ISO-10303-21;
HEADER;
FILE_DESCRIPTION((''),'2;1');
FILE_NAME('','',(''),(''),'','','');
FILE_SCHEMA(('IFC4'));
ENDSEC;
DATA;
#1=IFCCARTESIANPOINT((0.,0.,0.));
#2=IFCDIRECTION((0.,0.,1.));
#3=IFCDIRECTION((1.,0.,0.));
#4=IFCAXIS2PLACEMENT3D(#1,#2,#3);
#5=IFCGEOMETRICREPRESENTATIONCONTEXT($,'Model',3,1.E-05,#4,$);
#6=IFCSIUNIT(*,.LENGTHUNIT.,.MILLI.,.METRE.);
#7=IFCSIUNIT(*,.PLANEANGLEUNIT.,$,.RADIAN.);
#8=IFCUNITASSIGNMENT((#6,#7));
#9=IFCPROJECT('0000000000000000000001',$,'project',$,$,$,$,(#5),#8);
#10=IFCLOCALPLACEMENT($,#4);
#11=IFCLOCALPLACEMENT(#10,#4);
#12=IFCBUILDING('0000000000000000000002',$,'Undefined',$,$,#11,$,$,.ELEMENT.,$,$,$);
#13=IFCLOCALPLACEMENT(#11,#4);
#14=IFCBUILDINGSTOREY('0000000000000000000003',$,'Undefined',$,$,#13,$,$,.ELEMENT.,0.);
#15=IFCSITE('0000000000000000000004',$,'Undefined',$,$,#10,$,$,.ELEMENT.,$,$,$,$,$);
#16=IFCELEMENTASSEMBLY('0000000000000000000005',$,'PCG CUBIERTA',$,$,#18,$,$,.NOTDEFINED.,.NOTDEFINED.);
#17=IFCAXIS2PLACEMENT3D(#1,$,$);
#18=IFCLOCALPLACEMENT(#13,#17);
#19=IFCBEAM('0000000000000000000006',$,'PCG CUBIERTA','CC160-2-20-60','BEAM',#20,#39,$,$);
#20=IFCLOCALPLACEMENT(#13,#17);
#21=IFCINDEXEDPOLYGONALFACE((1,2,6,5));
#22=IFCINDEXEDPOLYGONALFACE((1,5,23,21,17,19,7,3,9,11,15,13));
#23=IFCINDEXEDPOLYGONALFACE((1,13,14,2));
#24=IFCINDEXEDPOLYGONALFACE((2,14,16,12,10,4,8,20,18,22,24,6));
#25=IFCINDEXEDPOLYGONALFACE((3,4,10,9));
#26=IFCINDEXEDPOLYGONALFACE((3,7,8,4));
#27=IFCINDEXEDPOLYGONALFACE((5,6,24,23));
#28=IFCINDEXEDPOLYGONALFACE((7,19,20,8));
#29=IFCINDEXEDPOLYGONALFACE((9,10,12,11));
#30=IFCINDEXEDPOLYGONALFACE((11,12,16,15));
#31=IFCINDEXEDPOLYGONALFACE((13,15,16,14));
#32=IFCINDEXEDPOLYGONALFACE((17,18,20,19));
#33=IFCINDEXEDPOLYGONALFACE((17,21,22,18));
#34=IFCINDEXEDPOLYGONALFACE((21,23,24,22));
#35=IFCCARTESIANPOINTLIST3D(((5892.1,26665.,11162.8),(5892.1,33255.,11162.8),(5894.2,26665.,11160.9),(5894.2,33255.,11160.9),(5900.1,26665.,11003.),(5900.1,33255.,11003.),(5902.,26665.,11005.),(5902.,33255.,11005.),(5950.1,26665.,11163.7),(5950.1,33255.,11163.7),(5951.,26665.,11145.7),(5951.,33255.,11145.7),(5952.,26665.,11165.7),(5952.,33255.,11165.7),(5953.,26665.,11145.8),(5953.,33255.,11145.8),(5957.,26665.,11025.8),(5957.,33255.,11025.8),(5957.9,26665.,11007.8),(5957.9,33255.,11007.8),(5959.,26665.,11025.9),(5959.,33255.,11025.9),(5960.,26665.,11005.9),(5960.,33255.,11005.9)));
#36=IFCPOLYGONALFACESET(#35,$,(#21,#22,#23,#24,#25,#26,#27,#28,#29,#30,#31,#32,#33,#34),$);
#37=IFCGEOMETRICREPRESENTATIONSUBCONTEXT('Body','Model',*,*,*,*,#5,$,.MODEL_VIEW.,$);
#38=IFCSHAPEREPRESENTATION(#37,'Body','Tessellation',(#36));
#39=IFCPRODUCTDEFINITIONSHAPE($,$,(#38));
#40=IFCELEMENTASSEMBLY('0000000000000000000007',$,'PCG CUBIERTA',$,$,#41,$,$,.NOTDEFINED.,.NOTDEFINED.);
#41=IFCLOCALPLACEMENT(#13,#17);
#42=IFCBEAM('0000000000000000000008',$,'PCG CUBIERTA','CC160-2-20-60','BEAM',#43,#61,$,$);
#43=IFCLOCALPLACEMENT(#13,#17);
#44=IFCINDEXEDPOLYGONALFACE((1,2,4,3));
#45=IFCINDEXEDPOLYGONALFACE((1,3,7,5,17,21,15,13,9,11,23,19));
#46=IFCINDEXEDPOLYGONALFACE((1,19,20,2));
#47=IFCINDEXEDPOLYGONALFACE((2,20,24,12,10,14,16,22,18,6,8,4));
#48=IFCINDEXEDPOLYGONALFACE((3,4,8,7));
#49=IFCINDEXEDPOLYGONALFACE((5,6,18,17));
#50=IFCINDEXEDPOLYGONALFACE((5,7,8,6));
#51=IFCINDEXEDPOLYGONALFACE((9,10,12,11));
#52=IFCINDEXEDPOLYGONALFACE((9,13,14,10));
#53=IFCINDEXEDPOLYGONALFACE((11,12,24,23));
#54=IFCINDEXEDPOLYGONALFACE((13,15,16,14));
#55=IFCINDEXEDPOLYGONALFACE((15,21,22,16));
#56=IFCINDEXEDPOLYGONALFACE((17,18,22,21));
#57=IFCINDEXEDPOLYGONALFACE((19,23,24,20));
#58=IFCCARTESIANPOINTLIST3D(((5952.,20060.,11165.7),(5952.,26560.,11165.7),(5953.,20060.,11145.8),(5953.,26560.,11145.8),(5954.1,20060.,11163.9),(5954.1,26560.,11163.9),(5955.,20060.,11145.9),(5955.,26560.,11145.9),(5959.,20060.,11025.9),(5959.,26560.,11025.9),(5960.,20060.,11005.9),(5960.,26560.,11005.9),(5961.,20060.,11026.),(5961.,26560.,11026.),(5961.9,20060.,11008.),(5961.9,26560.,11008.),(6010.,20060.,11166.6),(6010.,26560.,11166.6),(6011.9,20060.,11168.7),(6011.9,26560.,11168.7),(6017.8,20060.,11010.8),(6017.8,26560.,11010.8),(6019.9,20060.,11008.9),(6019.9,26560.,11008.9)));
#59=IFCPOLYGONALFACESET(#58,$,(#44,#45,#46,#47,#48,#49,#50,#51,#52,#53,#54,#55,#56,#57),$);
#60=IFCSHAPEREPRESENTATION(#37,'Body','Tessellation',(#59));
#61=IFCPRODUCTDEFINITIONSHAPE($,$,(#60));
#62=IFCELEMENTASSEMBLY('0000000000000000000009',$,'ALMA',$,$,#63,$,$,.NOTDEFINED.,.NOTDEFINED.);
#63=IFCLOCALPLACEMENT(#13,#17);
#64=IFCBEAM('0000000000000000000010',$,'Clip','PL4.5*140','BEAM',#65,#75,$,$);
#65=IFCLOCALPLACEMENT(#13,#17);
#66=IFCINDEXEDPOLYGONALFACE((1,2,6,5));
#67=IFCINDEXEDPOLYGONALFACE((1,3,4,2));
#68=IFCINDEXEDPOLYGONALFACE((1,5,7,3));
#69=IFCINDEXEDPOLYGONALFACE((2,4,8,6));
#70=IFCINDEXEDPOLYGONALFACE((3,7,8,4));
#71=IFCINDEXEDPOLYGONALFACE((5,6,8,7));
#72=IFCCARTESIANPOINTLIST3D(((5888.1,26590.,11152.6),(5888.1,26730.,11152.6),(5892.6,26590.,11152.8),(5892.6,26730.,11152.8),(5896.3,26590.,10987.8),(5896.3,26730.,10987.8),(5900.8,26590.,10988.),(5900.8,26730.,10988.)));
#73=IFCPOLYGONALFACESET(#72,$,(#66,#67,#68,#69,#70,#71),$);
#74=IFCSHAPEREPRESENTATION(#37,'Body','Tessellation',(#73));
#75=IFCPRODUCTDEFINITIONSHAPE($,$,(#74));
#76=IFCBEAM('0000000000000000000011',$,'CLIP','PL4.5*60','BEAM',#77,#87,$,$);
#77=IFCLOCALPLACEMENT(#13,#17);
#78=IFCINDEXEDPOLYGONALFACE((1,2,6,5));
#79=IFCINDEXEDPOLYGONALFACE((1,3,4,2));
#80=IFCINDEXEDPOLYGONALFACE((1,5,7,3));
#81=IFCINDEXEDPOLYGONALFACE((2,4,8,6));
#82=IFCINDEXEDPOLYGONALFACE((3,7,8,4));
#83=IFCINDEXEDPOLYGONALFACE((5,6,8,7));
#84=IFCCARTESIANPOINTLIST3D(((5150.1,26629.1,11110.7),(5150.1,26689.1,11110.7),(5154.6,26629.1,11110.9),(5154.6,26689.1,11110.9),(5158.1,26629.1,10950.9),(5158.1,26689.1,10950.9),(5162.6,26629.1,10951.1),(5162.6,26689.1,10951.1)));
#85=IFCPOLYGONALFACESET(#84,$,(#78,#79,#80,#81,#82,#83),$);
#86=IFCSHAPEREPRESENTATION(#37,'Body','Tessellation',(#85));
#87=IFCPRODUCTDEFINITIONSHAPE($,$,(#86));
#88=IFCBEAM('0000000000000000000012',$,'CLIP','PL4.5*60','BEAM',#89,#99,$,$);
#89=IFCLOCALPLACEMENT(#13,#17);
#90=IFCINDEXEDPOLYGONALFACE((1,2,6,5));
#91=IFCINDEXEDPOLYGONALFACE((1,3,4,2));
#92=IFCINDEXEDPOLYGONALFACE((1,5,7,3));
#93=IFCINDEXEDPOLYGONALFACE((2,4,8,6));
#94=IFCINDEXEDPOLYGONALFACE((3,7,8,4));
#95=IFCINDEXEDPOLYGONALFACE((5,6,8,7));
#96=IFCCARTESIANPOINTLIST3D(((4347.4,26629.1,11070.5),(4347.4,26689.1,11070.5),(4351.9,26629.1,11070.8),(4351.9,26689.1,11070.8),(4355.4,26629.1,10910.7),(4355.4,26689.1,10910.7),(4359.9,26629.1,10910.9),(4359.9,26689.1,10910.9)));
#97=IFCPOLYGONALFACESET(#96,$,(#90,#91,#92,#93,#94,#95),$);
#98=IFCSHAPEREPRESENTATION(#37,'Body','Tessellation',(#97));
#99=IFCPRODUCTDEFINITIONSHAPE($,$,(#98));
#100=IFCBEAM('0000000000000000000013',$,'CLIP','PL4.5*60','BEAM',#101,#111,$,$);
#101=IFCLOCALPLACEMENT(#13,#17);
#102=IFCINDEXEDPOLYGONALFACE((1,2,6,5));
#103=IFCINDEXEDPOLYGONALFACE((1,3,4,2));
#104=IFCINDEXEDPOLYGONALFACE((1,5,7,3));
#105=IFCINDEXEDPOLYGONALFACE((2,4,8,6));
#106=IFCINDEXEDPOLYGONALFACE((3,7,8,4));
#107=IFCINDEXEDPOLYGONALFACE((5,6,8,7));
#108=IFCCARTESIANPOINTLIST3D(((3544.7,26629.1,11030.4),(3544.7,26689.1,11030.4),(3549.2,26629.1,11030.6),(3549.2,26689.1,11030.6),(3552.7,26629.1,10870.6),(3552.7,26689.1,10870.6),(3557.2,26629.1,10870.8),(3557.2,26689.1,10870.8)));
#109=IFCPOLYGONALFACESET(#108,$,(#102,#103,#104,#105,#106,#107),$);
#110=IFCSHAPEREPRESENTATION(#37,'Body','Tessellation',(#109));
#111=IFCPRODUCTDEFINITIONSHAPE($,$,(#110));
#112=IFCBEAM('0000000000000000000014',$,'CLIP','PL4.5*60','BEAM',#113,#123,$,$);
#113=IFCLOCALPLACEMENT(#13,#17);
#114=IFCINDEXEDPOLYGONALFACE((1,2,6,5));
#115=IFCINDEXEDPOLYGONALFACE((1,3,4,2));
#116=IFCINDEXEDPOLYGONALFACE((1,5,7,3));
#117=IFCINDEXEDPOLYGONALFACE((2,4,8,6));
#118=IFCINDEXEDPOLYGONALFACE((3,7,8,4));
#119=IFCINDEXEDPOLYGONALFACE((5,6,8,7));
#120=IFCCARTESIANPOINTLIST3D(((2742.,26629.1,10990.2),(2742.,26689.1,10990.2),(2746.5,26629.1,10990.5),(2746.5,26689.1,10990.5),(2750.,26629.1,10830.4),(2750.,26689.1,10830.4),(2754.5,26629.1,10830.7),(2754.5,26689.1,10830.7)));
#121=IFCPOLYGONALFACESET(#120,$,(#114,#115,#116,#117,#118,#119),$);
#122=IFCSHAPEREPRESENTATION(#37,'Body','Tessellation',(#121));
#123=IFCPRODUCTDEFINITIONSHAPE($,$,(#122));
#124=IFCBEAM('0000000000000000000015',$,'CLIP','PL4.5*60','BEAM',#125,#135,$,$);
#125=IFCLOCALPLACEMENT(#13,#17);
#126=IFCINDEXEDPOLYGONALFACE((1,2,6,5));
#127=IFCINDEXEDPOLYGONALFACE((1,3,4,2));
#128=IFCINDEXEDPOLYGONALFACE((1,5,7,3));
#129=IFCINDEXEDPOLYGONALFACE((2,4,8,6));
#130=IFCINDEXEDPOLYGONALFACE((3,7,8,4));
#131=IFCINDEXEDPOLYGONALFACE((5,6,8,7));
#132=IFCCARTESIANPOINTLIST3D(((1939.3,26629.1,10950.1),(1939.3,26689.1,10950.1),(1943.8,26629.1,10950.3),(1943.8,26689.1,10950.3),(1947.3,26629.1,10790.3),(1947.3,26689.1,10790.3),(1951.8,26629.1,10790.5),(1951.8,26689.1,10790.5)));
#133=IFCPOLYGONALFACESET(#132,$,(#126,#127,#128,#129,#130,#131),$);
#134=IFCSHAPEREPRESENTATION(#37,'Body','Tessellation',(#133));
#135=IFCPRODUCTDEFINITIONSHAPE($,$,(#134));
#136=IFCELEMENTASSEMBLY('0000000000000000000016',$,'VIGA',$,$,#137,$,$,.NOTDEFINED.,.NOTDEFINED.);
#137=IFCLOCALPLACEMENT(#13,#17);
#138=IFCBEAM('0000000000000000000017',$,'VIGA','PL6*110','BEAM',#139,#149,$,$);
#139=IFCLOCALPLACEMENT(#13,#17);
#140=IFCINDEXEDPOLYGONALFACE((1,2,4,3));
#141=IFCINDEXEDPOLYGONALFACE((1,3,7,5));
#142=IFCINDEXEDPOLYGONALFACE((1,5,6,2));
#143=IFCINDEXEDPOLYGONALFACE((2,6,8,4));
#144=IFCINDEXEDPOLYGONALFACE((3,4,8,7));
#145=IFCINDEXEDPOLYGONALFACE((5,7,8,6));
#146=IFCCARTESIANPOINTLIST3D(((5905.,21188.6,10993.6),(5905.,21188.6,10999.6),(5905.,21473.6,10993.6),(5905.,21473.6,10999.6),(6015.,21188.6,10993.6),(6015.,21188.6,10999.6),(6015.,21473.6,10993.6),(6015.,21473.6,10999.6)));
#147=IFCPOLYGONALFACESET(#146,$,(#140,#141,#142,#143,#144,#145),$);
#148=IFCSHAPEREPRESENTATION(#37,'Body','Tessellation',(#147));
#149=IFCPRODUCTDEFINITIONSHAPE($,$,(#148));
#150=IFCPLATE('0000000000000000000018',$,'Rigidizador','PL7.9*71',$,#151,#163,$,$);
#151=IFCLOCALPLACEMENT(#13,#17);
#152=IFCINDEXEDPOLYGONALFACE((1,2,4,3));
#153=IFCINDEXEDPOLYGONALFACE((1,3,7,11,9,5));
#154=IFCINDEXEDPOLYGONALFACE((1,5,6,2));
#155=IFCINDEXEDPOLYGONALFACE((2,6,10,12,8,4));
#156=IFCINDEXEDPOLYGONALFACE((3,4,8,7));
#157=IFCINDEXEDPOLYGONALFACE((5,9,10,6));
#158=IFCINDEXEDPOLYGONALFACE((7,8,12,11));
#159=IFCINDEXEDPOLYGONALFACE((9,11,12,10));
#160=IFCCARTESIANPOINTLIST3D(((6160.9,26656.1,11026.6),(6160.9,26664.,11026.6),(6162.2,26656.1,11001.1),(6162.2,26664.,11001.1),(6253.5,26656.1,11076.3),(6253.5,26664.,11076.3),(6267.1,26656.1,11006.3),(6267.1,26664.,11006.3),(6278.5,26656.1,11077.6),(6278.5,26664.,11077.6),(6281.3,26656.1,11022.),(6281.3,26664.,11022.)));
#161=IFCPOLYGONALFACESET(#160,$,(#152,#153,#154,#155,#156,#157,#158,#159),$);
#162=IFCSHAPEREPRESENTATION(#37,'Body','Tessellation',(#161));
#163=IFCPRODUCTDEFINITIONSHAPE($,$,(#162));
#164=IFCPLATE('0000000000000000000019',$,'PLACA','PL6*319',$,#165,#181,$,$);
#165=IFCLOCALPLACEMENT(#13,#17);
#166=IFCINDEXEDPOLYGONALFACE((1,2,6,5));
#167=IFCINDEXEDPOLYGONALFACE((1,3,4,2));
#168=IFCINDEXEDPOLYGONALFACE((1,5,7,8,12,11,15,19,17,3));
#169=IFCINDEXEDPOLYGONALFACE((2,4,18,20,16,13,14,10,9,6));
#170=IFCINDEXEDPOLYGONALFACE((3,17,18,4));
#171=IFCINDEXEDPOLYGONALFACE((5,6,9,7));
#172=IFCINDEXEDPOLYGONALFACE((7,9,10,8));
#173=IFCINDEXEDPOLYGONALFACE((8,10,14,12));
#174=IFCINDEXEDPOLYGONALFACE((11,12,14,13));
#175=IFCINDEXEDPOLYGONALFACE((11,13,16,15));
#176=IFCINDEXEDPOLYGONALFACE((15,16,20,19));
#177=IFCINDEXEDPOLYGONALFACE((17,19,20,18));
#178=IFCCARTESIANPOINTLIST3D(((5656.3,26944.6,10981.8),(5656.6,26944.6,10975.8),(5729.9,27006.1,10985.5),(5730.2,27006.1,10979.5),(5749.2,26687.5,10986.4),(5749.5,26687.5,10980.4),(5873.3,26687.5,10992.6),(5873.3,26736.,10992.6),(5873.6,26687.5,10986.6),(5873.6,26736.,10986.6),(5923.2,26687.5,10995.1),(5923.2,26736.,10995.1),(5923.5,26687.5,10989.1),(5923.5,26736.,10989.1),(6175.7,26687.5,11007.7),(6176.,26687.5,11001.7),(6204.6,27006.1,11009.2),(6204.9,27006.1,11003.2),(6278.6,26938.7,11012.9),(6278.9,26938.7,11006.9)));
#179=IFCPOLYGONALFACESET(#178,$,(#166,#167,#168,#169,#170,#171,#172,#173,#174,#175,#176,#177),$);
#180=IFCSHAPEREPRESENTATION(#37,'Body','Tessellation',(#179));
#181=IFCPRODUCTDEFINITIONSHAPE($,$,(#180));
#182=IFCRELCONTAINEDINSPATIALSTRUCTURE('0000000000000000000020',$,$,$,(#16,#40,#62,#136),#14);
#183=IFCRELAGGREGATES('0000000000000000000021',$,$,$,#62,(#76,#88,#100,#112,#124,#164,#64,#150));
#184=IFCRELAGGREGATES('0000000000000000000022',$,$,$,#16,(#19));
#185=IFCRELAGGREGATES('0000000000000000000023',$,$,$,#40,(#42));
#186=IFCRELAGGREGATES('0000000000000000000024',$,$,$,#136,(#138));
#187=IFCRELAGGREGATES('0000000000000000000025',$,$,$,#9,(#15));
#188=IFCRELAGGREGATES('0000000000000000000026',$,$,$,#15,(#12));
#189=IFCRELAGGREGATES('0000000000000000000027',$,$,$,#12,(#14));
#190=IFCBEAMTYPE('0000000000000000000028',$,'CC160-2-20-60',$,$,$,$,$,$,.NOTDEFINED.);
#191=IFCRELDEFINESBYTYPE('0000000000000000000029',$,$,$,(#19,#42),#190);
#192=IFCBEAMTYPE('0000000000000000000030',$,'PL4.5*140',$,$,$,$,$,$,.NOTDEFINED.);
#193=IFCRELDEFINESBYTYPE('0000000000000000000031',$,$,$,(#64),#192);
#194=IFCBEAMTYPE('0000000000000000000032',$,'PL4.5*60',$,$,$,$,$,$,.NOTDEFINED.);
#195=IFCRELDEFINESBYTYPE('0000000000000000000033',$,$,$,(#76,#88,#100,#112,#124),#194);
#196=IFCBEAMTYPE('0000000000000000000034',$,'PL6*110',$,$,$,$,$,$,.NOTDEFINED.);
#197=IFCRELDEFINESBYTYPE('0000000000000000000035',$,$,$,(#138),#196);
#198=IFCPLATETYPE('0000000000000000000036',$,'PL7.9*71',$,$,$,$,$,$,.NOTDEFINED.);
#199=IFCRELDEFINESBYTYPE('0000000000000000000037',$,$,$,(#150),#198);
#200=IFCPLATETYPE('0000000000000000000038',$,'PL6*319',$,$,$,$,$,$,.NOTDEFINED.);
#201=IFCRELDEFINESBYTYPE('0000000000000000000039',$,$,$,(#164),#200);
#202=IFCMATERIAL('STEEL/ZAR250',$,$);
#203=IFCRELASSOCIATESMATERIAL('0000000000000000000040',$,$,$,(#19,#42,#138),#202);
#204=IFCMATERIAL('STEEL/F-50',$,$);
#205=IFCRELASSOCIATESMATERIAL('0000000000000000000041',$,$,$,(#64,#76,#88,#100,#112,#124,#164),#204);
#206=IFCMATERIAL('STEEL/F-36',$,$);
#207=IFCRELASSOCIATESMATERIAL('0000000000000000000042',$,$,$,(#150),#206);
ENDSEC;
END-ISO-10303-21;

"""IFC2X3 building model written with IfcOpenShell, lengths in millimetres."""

from ifc_helpers import new_model, si_unit, frame, origin_with_axes, origin_2d_with_axis, place, context, subcontext, project, spatial, polyline, rectangle, c_section, outline, extrude, boolean, material, type_object, element, aggregate, save


model = new_model("IFC2X3")

# Units and contexts
model_context = context("Model", 3, precision=1e-05, world=origin_with_axes())
body_context = subcontext(model_context, "Body", "Model", "MODEL_VIEW")
ifc_project = project(units=[si_unit("LENGTHUNIT", "METRE", prefix="MILLI"), si_unit("PLANEANGLEUNIT", "RADIAN")], contexts=[model_context])

# Site, building, storey
site_placement = place(None, origin_with_axes())
site = spatial("IfcSite", under=ifc_project, at=site_placement, Name="Undefined", CompositionType="ELEMENT")
building_placement = place(site_placement, origin_with_axes())
building = spatial("IfcBuilding", under=site, at=building_placement, Name="Undefined", CompositionType="ELEMENT")
storey_placement = place(building_placement, origin_with_axes())
storey = spatial("IfcBuildingStorey", under=building, at=storey_placement, Name="Undefined", CompositionType="ELEMENT", Elevation=0.0)

# Element assemblies, beams
assembly_1_placement = place(storey_placement, origin_with_axes())
assembly_1 = element("IfcElementAssembly", 1, at=assembly_1_placement, inside=storey, Name="PCG CUBIERTA", AssemblyPlace="NOTDEFINED", PredefinedType="NOTDEFINED")
ifc_material_1 = material(Name="STEEL/ZAR250")
beam_type_1 = type_object("IfcBeamType", Name="CC160-2-20-60", PredefinedType="NOTDEFINED")
beam_1_placement = place(assembly_1_placement, frame((5926.0, 26665.0, 11084.4), z_axis=(-0.049943, 0.0, 0.998752), x_axis=(0.0, 1.0, 0.0)))
beam_1 = element("IfcBeam", 2, at=beam_1_placement, type_object=beam_type_1, material=ifc_material_1, Name="PCG CUBIERTA", Description="CC160-2-20-60", ObjectType="BEAM", context=body_context, shape_type="SweptSolid", body=[
    extrude(c_section(Depth=160.0, Width=60.0, WallThickness=2.0, Girth=20.0, at=origin_2d_with_axis()), frame((6590.0, 0.0, 0.0), z_axis=(-1.0, 0.0, 0.0), x_axis=(0.0, -1.0, 0.0)), (0.0, 0.0, 1.0), 6590.0),
])
assembly_2_placement = place(storey_placement, origin_with_axes())
assembly_2 = element("IfcElementAssembly", 3, at=assembly_2_placement, inside=storey, Name="PCG CUBIERTA", AssemblyPlace="NOTDEFINED", PredefinedType="NOTDEFINED")
beam_2_placement = place(assembly_2_placement, frame((5986.0, 26560.0, 11087.3), z_axis=(-0.049943, 0.0, 0.998752), x_axis=(0.0, -1.0, 0.0)))
beam_2 = element("IfcBeam", 4, at=beam_2_placement, type_object=beam_type_1, material=ifc_material_1, Name="PCG CUBIERTA", Description="CC160-2-20-60", ObjectType="BEAM", context=body_context, shape_type="SweptSolid", body=[
    extrude(c_section(Depth=160.0, Width=60.0, WallThickness=2.0, Girth=20.0, at=origin_2d_with_axis()), frame((6500.0, 0.0, 0.0), z_axis=(-1.0, 0.0, 0.0), x_axis=(0.0, -1.0, 0.0)), (0.0, 0.0, 1.0), 6500.0),
])

# Element assembly, beams
assembly_3_placement = place(storey_placement, origin_with_axes())
assembly_3 = element("IfcElementAssembly", 5, at=assembly_3_placement, inside=storey, Name="ALMA", AssemblyPlace="NOTDEFINED", PredefinedType="NOTDEFINED")
ifc_material_2 = material(Name="STEEL/F-50")
beam_type_2 = type_object("IfcBeamType", Name="PL4.5*140", PredefinedType="NOTDEFINED")
beam_3_placement = place(assembly_3_placement, frame((5890.3, 26660.0, 11152.7), z_axis=(0.0, -1.0, 0.0), x_axis=(0.049943, 0.0, -0.998752)))
beam_3 = element("IfcBeam", 6, at=beam_3_placement, type_object=beam_type_2, material=ifc_material_2, Name="Clip", Description="PL4.5*140", ObjectType="BEAM", context=body_context, shape_type="SweptSolid", body=[
    extrude(rectangle(XDim=4.5, YDim=140.0, at=origin_2d_with_axis()), frame((165.0, 0.0, 0.0), z_axis=(-1.0, 0.0, 0.0), x_axis=(0.0, -1.0, 0.0)), (0.0, 0.0, 1.0), 165.0),
])
beam_type_3 = type_object("IfcBeamType", Name="PL4.5*60", PredefinedType="NOTDEFINED")
beam_4_placement = place(assembly_3_placement, frame((5152.3, 26659.1, 11110.8), z_axis=(0.0, 1.0, 0.0), x_axis=(0.049943, 0.0, -0.998752)))
beam_4 = element("IfcBeam", 7, at=beam_4_placement, type_object=beam_type_3, material=ifc_material_2, Name="CLIP", Description="PL4.5*60", ObjectType="BEAM", context=body_context, shape_type="SweptSolid", body=[
    extrude(rectangle(XDim=4.5, YDim=60.0, at=origin_2d_with_axis()), frame((160.0, 0.0, 0.0), z_axis=(-1.0, 0.0, 0.0), x_axis=(0.0, -1.0, 0.0)), (0.0, 0.0, 1.0), 160.0),
])
beam_5_placement = place(assembly_3_placement, frame((4349.6, 26659.1, 11070.6), z_axis=(0.0, 1.0, 0.0), x_axis=(0.049943, 0.0, -0.998752)))
beam_5 = element("IfcBeam", 8, at=beam_5_placement, type_object=beam_type_3, material=ifc_material_2, Name="CLIP", Description="PL4.5*60", ObjectType="BEAM", context=body_context, shape_type="SweptSolid", body=[
    extrude(rectangle(XDim=4.5, YDim=60.0, at=origin_2d_with_axis()), frame((160.0, 0.0, 0.0), z_axis=(-1.0, 0.0, 0.0), x_axis=(0.0, -1.0, 0.0)), (0.0, 0.0, 1.0), 160.0),
])
beam_6_placement = place(assembly_3_placement, frame((3546.9, 26659.1, 11030.5), z_axis=(0.0, 1.0, 0.0), x_axis=(0.049943, 0.0, -0.998752)))
beam_6 = element("IfcBeam", 9, at=beam_6_placement, type_object=beam_type_3, material=ifc_material_2, Name="CLIP", Description="PL4.5*60", ObjectType="BEAM", context=body_context, shape_type="SweptSolid", body=[
    extrude(rectangle(XDim=4.5, YDim=60.0, at=origin_2d_with_axis()), frame((160.0, 0.0, 0.0), z_axis=(-1.0, 0.0, 0.0), x_axis=(0.0, -1.0, 0.0)), (0.0, 0.0, 1.0), 160.0),
])
beam_7_placement = place(assembly_3_placement, frame((2744.2, 26659.1, 10990.4), z_axis=(0.0, 1.0, 0.0), x_axis=(0.049943, 0.0, -0.998752)))
beam_7 = element("IfcBeam", 10, at=beam_7_placement, type_object=beam_type_3, material=ifc_material_2, Name="CLIP", Description="PL4.5*60", ObjectType="BEAM", context=body_context, shape_type="SweptSolid", body=[
    extrude(rectangle(XDim=4.5, YDim=60.0, at=origin_2d_with_axis()), frame((160.0, 0.0, 0.0), z_axis=(-1.0, 0.0, 0.0), x_axis=(0.0, -1.0, 0.0)), (0.0, 0.0, 1.0), 160.0),
])
beam_8_placement = place(assembly_3_placement, frame((1941.6, 26659.1, 10950.2), z_axis=(0.0, 1.0, 0.0), x_axis=(0.049943, 0.0, -0.998752)))
beam_8 = element("IfcBeam", 11, at=beam_8_placement, type_object=beam_type_3, material=ifc_material_2, Name="CLIP", Description="PL4.5*60", ObjectType="BEAM", context=body_context, shape_type="SweptSolid", body=[
    extrude(rectangle(XDim=4.5, YDim=60.0, at=origin_2d_with_axis()), frame((160.0, 0.0, 0.0), z_axis=(-1.0, 0.0, 0.0), x_axis=(0.0, -1.0, 0.0)), (0.0, 0.0, 1.0), 160.0),
])

# Element assembly, beam
assembly_4_placement = place(storey_placement, origin_with_axes())
assembly_4 = element("IfcElementAssembly", 12, at=assembly_4_placement, inside=storey, Name="VIGA", AssemblyPlace="NOTDEFINED", PredefinedType="NOTDEFINED")
beam_type_4 = type_object("IfcBeamType", Name="PL6*110", PredefinedType="NOTDEFINED")
beam_9_placement = place(assembly_4_placement, frame((5960.0, 21473.6, 10996.6), z_axis=(-1.0, 0.0, 0.0), x_axis=(0.0, -1.0, 0.0)))
beam_9 = element("IfcBeam", 13, at=beam_9_placement, type_object=beam_type_4, material=ifc_material_1, Name="VIGA", Description="PL6*110", ObjectType="BEAM", context=body_context, shape_type="SweptSolid", body=[
    extrude(rectangle(XDim=6.0, YDim=110.0, at=origin_2d_with_axis()), frame((285.0, 0.0, 0.0), z_axis=(-1.0, 0.0, 0.0), x_axis=(0.0, -1.0, 0.0)), (0.0, 0.0, 1.0), 285.0),
])

# Plates
ifc_material_3 = material(Name="STEEL/F-36")
plate_type_1 = type_object("IfcPlateType", Name="PL7.9*71", PredefinedType="NOTDEFINED")
plate_1_placement = place(assembly_3_placement, frame((6278.5, 26660.0, 11077.6), z_axis=(0.0, 1.0, 0.0), x_axis=(0.049943, 0.0, -0.998752)))
plate_1 = element("IfcPlate", 14, at=plate_1_placement, type_object=plate_type_1, material=ifc_material_3, Name="Rigidizador", Description="PL7.9*71", context=body_context, shape_type="SweptSolid", body=[
    extrude(outline(polyline([(0.0, 0.0), (55.6, 0.0), (70.6, 15.0), (70.6, 120.0), (45.0, 120.0), (0.0, 25.0), (0.0, 0.0)])), frame((0.0, 0.0, -4.0), z_axis=(0.0, 0.0, 1.0), x_axis=(1.0, 0.0, 0.0)), (0.0, 0.0, 1.0), 7.9),
])
plate_type_2 = type_object("IfcPlateType", Name="PL6*319", PredefinedType="NOTDEFINED")
plate_2_placement = place(assembly_3_placement, frame((6175.8, 26687.5, 11004.7), z_axis=(0.049943, 0.0, -0.998752), x_axis=(-0.998752, 0.0, -0.049943)))
plate_2 = element("IfcPlate", 15, at=plate_2_placement, type_object=plate_type_2, material=ifc_material_2, Name="PLACA", Description="PL6*319", context=body_context, shape_type="CSG", body=[
    boolean("DIFFERENCE", extrude(outline(polyline([(0.0, 0.0), (427.0, 0.0), (520.0, 257.1), (446.3, 318.6), (-29.0, 318.6), (-103.1, 251.2), (0.0, 0.0)])), frame((0.0, 0.0, -3.0), z_axis=(0.0, 0.0, 1.0), x_axis=(1.0, 0.0, 0.0)), (0.0, 0.0, 1.0), 6.0), extrude(outline(polyline([(0.0, 0.0), (60.0, 0.0), (60.0, 50.0), (0.0, 50.0), (0.0, 0.0)])), frame((252.8, -11.5, 6.0), z_axis=(0.0, 0.0, -1.0), x_axis=(0.0, 1.0, 0.0)), (0.0, 0.0, 1.0), 12.0)),
])
aggregate(assembly_3, [beam_4, beam_5, beam_6, beam_7, beam_8, plate_2, beam_3, plate_1])

aggregate(assembly_1, [beam_1])
aggregate(assembly_2, [beam_2])

aggregate(assembly_4, [beam_9])

save(model, "model.ifc")
